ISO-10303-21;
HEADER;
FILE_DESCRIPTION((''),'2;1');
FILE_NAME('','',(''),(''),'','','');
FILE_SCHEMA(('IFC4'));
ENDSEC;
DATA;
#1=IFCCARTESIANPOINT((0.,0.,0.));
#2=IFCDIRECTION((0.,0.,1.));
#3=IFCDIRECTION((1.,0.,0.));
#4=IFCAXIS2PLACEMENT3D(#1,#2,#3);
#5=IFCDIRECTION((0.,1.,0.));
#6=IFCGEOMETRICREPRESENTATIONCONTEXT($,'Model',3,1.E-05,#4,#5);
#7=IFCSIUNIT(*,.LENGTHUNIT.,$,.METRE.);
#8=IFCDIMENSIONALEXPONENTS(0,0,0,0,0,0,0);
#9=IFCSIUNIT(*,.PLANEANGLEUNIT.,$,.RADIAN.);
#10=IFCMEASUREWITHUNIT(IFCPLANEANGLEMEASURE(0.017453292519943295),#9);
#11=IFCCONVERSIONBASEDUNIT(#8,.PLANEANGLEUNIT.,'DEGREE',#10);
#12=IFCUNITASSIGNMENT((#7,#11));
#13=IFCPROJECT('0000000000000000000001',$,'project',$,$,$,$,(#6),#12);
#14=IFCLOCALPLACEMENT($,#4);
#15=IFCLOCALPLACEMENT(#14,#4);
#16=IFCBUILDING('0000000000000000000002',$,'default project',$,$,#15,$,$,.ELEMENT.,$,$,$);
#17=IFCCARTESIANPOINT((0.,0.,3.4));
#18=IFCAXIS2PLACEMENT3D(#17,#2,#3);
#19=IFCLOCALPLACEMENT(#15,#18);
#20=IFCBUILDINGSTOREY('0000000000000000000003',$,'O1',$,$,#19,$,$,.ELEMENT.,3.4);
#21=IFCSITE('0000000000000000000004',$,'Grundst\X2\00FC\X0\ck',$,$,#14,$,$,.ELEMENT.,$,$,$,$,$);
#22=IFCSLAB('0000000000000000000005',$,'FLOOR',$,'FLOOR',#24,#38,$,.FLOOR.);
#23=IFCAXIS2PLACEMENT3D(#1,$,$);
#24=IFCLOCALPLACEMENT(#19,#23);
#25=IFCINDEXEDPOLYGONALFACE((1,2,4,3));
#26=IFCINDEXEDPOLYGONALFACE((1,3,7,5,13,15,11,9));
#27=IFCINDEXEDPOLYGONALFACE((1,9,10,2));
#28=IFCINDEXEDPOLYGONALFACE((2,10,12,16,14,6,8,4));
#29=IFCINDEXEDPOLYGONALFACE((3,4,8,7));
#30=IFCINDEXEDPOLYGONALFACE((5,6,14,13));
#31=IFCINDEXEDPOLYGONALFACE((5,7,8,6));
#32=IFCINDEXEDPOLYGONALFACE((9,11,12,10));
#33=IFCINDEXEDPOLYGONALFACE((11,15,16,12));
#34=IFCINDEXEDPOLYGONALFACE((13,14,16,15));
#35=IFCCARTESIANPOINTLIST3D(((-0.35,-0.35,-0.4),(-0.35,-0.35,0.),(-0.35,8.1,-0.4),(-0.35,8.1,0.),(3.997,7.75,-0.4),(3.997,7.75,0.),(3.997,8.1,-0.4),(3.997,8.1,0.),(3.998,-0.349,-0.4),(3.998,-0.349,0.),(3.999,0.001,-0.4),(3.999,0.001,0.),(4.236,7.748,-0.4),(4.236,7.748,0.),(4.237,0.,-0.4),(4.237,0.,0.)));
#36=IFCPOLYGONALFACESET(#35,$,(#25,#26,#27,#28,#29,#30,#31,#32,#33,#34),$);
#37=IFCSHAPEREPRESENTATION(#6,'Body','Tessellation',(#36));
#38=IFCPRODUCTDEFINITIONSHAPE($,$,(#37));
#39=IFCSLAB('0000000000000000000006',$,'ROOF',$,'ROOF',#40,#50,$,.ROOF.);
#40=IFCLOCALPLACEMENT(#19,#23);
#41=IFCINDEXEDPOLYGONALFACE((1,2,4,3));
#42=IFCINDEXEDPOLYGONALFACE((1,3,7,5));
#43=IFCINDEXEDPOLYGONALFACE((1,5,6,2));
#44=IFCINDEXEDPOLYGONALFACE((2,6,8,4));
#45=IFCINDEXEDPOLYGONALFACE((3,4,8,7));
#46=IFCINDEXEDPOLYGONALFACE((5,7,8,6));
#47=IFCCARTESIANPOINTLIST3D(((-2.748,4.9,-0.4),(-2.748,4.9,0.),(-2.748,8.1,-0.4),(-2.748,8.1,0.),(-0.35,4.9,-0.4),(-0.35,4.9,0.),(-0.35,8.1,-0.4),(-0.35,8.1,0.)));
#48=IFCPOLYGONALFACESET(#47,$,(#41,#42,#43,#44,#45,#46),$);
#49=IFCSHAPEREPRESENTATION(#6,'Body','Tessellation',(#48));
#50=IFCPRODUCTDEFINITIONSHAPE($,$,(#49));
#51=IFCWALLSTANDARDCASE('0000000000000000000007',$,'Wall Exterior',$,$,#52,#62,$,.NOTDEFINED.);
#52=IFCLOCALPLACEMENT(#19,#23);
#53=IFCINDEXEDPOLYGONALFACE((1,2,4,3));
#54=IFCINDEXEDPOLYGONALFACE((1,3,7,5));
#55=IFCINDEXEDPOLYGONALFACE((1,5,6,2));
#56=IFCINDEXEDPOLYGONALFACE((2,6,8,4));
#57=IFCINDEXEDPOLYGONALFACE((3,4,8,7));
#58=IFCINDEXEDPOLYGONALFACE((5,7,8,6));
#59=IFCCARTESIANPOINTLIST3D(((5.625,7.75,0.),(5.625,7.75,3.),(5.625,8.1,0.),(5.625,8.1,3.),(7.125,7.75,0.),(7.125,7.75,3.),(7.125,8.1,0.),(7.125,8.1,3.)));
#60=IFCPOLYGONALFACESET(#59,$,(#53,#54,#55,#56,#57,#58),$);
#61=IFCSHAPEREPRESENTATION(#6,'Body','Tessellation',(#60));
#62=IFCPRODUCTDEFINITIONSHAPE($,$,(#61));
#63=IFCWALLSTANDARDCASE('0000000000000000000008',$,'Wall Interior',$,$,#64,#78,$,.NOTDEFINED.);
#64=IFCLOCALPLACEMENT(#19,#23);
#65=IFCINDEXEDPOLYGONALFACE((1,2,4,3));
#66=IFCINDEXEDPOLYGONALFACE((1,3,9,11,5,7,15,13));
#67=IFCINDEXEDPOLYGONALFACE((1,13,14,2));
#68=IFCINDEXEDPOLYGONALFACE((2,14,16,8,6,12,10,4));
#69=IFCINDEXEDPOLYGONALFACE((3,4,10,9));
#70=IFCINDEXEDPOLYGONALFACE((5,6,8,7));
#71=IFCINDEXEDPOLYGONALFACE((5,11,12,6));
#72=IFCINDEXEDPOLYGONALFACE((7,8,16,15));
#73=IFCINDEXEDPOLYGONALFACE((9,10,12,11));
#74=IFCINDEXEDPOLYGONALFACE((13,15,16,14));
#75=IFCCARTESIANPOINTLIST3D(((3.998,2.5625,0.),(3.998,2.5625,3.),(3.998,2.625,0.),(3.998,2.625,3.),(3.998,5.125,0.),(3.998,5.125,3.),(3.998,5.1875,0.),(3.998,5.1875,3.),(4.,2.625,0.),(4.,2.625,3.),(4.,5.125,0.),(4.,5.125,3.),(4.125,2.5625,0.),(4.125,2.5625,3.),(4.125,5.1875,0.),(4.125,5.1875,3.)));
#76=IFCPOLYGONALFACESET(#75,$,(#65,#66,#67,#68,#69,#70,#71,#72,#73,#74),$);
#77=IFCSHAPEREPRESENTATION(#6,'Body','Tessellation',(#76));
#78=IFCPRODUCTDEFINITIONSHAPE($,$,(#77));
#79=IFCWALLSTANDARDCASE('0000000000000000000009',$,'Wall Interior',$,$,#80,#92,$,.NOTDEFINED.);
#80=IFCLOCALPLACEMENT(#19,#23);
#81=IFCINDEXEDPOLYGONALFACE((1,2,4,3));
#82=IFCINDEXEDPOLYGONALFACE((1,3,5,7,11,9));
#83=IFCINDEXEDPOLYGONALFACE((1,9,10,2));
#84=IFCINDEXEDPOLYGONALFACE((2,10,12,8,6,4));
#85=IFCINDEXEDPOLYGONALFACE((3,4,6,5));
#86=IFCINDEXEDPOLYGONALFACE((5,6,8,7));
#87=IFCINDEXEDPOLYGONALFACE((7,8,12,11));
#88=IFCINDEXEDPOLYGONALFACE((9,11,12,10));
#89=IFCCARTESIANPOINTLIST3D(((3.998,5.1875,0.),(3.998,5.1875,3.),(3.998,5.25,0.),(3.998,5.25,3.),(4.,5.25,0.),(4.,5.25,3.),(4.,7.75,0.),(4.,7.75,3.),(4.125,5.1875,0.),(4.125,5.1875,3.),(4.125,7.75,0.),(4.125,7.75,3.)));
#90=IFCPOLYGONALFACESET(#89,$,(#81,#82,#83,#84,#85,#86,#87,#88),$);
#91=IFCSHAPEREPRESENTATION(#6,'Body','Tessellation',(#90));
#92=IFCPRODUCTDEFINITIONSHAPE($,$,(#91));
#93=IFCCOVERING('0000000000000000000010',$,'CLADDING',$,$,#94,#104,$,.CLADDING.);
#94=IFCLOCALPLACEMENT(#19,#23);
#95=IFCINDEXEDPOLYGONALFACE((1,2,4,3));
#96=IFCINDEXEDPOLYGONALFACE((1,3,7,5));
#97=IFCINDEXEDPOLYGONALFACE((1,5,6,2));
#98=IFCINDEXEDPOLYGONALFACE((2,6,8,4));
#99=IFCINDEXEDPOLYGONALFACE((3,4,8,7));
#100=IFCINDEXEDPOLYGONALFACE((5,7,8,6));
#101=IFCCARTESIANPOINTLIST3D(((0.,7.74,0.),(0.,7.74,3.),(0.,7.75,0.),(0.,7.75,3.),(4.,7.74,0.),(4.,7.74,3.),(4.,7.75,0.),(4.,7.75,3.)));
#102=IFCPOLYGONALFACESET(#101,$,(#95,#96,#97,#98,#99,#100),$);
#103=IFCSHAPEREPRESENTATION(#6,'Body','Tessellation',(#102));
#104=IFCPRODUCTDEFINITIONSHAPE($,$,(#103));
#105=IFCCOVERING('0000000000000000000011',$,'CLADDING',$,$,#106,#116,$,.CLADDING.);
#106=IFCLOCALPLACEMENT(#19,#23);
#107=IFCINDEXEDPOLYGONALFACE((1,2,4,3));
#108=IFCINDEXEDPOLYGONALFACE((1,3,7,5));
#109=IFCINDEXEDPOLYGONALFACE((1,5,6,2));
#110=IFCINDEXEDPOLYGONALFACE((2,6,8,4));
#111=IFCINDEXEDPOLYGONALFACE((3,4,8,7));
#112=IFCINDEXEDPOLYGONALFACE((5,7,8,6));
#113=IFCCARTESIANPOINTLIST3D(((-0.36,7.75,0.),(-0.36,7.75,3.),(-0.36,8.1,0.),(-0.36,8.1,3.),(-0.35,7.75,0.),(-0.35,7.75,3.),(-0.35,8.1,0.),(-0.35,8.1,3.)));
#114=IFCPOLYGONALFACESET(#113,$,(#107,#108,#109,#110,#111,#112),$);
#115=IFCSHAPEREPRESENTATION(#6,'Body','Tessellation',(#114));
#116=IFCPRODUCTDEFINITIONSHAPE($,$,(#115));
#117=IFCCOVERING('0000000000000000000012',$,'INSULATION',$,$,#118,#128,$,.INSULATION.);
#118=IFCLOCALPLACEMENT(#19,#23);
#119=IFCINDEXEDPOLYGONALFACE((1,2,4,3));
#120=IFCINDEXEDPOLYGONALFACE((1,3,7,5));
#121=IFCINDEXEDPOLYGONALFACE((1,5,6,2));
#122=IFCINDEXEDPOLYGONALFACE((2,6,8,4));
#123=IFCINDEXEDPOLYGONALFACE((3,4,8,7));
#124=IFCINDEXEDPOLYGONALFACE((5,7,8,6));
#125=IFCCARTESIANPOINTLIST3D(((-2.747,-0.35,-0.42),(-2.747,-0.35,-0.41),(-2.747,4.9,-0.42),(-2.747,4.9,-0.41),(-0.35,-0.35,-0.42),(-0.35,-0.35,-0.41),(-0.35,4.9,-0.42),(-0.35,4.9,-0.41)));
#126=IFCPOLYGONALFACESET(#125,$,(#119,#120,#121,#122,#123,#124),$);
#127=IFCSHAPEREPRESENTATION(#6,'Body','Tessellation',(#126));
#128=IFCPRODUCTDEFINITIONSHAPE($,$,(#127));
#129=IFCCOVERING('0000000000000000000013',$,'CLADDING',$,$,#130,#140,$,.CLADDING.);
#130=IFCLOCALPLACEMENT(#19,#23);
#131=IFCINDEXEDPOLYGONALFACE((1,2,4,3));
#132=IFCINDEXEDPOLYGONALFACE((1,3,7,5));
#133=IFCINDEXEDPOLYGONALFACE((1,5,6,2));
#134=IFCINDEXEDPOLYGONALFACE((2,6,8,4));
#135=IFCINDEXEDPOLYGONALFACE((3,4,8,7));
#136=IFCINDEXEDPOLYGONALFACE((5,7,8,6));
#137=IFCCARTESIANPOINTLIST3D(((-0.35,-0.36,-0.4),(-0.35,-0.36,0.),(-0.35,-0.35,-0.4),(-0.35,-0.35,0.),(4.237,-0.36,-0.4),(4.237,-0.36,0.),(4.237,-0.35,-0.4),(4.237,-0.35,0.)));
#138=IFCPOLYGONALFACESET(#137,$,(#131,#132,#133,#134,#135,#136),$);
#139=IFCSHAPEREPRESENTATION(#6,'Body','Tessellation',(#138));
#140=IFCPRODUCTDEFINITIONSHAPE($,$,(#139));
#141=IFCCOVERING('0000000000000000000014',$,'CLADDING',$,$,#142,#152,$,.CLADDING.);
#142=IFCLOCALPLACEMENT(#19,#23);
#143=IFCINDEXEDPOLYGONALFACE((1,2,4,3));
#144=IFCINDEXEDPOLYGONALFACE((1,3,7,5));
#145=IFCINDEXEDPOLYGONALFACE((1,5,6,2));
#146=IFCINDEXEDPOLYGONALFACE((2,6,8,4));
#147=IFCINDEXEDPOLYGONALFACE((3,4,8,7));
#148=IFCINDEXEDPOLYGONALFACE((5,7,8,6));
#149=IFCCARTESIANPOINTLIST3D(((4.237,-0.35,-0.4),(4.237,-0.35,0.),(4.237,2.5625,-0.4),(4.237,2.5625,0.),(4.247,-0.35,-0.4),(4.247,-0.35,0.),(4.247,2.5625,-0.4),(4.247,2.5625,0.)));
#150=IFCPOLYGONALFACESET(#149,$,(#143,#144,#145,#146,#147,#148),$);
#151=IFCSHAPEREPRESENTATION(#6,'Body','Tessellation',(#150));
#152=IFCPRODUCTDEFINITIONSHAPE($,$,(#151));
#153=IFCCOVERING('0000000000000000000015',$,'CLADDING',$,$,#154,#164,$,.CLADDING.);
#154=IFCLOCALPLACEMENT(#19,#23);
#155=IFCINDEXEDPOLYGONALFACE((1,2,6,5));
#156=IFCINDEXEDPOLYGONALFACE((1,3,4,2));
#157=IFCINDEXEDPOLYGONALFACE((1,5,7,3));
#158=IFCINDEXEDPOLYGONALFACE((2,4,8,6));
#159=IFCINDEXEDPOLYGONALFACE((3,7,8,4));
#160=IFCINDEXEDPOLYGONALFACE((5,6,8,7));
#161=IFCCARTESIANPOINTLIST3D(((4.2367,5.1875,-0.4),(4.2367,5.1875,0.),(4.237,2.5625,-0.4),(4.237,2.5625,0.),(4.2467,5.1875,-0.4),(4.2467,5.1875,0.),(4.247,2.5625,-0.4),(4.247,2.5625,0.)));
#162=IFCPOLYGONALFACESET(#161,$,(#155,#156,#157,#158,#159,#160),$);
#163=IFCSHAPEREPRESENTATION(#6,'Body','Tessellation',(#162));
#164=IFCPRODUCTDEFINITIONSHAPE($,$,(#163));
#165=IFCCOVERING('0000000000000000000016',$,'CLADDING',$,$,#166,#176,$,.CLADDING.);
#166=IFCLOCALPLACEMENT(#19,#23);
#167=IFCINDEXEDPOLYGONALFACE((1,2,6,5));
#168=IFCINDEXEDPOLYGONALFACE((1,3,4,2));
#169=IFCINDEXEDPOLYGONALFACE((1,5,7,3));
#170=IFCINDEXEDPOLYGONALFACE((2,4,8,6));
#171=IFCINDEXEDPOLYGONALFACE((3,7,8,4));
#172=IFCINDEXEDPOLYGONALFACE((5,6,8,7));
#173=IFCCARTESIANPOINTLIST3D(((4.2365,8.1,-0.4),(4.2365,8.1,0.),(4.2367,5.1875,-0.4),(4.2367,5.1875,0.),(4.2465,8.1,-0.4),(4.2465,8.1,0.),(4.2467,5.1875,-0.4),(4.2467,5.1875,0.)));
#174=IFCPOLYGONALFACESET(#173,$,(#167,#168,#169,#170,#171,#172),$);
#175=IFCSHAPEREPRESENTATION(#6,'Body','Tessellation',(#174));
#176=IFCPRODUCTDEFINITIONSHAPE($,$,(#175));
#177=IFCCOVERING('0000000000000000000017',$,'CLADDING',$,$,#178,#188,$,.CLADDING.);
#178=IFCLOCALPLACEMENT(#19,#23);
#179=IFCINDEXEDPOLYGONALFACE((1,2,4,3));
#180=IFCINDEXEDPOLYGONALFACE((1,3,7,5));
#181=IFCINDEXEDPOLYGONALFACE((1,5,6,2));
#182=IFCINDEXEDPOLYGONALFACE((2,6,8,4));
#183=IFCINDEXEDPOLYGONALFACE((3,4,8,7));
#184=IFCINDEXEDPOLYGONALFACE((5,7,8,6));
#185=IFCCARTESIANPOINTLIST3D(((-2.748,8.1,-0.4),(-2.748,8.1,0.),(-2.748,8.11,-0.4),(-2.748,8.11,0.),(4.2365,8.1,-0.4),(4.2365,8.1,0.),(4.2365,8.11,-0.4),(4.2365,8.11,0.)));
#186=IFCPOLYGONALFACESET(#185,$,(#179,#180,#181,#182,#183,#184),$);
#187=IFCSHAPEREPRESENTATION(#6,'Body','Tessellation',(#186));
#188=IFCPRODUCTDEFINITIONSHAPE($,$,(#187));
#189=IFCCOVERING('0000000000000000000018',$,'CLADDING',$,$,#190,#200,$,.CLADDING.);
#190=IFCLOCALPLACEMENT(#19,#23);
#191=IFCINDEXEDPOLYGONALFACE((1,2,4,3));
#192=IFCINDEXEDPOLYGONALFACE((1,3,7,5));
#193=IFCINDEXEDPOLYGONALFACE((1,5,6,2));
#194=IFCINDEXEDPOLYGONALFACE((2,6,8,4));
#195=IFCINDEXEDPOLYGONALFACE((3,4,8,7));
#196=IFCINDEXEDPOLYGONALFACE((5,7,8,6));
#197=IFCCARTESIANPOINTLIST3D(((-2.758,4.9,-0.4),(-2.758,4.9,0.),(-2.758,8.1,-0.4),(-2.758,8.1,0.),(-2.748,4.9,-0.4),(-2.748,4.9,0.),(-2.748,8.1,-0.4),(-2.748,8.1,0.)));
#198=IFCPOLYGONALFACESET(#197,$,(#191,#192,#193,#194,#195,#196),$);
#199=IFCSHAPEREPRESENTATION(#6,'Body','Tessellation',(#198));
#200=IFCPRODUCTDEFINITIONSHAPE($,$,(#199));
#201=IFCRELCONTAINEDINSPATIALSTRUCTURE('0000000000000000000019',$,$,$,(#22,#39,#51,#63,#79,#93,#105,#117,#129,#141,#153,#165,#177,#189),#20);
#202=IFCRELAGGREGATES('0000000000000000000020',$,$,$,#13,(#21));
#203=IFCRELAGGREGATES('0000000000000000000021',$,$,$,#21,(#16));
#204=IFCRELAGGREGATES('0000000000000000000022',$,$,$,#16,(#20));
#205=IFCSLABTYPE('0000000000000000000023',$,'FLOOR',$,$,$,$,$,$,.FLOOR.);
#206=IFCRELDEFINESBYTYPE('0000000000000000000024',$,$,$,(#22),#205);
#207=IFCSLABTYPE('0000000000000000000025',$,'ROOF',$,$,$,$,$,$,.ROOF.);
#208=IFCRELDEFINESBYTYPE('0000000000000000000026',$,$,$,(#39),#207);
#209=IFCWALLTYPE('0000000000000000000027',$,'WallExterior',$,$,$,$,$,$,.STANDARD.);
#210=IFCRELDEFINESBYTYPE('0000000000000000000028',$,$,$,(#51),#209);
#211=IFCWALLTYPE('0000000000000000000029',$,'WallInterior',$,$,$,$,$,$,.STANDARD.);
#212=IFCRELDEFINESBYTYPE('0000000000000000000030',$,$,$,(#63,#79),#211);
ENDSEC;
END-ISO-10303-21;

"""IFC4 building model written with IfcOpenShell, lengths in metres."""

from ifc_helpers import new_model, entity, si_unit, converted_unit, direction, frame, origin_with_axes, place, context, project, spatial, polyline, outline, extrude, type_object, element, save


model = new_model("IFC4")

# Units and contexts
model_context = context("Model", 3, precision=1e-05, world=origin_with_axes(), true_north=direction((0.0, 1.0, 0.0)))
ifc_project = project(units=[si_unit("LENGTHUNIT", "METRE"), converted_unit("PLANEANGLEUNIT", "DEGREE", entity("IfcPlaneAngleMeasure", 0.017453292519943295), si_unit("PLANEANGLEUNIT", "RADIAN"), dimensions=[0, 0, 0, 0, 0, 0, 0])], contexts=[model_context])

# Site, building, storey
site_placement = place(None, origin_with_axes())
site = spatial("IfcSite", under=ifc_project, at=site_placement, Name="Grundstück", CompositionType="ELEMENT")
building_placement = place(site_placement, origin_with_axes())
building = spatial("IfcBuilding", under=site, at=building_placement, Name="default project", CompositionType="ELEMENT")
placement_1 = place(building_placement, frame((0.0, 0.0, 3.4), z_axis=(0.0, 0.0, 1.0), x_axis=(1.0, 0.0, 0.0)))
storey = spatial("IfcBuildingStorey", under=building, at=placement_1, Name="O1", CompositionType="ELEMENT", Elevation=3.4)

# Slabs
slab_type_1 = type_object("IfcSlabType", Name="FLOOR", PredefinedType="FLOOR")
slab_1_placement = place(placement_1, frame((0.0, 0.0, -0.4), z_axis=(0.0, 0.0, 1.0), x_axis=(1.0, 0.0, 0.0)))
element("IfcSlab", 1, at=slab_1_placement, inside=storey, type_object=slab_type_1, Name="FLOOR", ObjectType="FLOOR", PredefinedType="FLOOR", context=model_context, shape_type="SweptSolid", body=[
    extrude(outline(polyline([(4.237, 0.0), (4.236, 7.748), (3.997, 7.75), (3.997, 8.1), (-0.35, 8.1), (-0.35, -0.35), (3.998, -0.349), (3.999, 0.001), (4.237, 0.0)])), origin_with_axes(), (0.0, 0.0, 1.0), 0.4),
])
slab_type_2 = type_object("IfcSlabType", Name="ROOF", PredefinedType="ROOF")
slab_2_placement = place(placement_1, frame((0.0, 0.0, -0.4), z_axis=(0.0, 0.0, 1.0), x_axis=(1.0, 0.0, 0.0)))
element("IfcSlab", 2, at=slab_2_placement, inside=storey, type_object=slab_type_2, Name="ROOF", ObjectType="ROOF", PredefinedType="ROOF", context=model_context, shape_type="SweptSolid", body=[
    extrude(outline(polyline([(-0.35, 8.1), (-2.748, 8.1), (-2.748, 4.9), (-0.35, 4.9), (-0.35, 8.1)])), origin_with_axes(), (0.0, 0.0, 1.0), 0.4),
])

# Walls
wall_type_1 = type_object("IfcWallType", Name="WallExterior", PredefinedType="STANDARD")
placement_2 = place(placement_1, frame((5.625, 7.925, 0.0), z_axis=(0.0, 0.0, 1.0), x_axis=(1.0, 0.0, 0.0)))
element("IfcWallStandardCase", 3, at=placement_2, inside=storey, type_object=wall_type_1, Name="Wall Exterior", PredefinedType="NOTDEFINED", context=model_context, shape_type="SweptSolid", body=[
    extrude(outline(polyline([(1.5, 0.175), (0.0, 0.175), (0.0, -0.175), (1.5, -0.175), (1.5, 0.175)])), origin_with_axes(), (0.0, 0.0, 1.0), 3.0),
])
placement_3 = place(placement_1, frame((-0.175, 7.925, 0.0), z_axis=(0.0, 0.0, 1.0), x_axis=(1.0, 0.0, 0.0)))
wall_type_2 = type_object("IfcWallType", Name="WallInterior", PredefinedType="STANDARD")
wall_1_placement = place(placement_1, frame((4.0625, 2.5625, 0.0), z_axis=(0.0, 0.0, 1.0), x_axis=(0.0, 1.0, 0.0)))
element("IfcWallStandardCase", 4, at=wall_1_placement, inside=storey, type_object=wall_type_2, Name="Wall Interior", PredefinedType="NOTDEFINED", context=model_context, shape_type="SweptSolid", body=[
    extrude(outline(polyline([(2.5625, 0.0625), (0.0625, 0.0625), (0.0625, 0.0645), (0.0, 0.0645), (0.0, -0.0625), (2.625, -0.0625), (2.625, 0.0645), (2.5625, 0.0645), (2.5625, 0.0625)])), origin_with_axes(), (0.0, 0.0, 1.0), 3.0),
])
wall_2_placement = place(placement_1, frame((4.0625, 5.1875, 0.0), z_axis=(0.0, 0.0, 1.0), x_axis=(0.0, 1.0, 0.0)))
element("IfcWallStandardCase", 5, at=wall_2_placement, inside=storey, type_object=wall_type_2, Name="Wall Interior", PredefinedType="NOTDEFINED", context=model_context, shape_type="SweptSolid", body=[
    extrude(outline(polyline([(0.0625, 0.0645), (0.0, 0.0645), (0.0, -0.0625), (2.5625, -0.0625), (2.5625, 0.0625), (0.0625, 0.0625), (0.0625, 0.0645)])), origin_with_axes(), (0.0, 0.0, 1.0), 3.0),
])

# Coverings
element("IfcCovering", 6, at=placement_1, inside=storey, Name="CLADDING", PredefinedType="CLADDING", context=model_context, shape_type="SweptSolid", body=[
    extrude(outline(polyline([(0.0, 7.74), (4.0, 7.74), (4.0, 7.75), (0.0, 7.75), (0.0, 7.74)])), origin_with_axes(), (0.0, 0.0, 1.0), 3.0),
])
element("IfcCovering", 7, at=placement_3, inside=storey, Name="CLADDING", PredefinedType="CLADDING", context=model_context, shape_type="SweptSolid", body=[
    extrude(outline(polyline([(-0.185, 0.175), (-0.185, -0.175), (-0.175, -0.175), (-0.175, 0.175), (-0.185, 0.175)])), origin_with_axes(), (0.0, 0.0, 1.0), 3.0),
])
placement_4 = place(placement_1, frame((0.0, 0.0, -0.4), z_axis=(0.0, 0.0, 1.0), x_axis=(1.0, 0.0, 0.0)))
covering_1_placement = place(placement_4, frame((0.0, 0.0, -0.01), z_axis=(0.0, 0.0, 1.0), x_axis=(1.0, 0.0, 0.0)))
element("IfcCovering", 8, at=covering_1_placement, inside=storey, Name="INSULATION", PredefinedType="INSULATION", context=model_context, shape_type="SweptSolid", body=[
    extrude(outline(polyline([(-0.35, 4.9), (-2.747, 4.9), (-2.747, -0.35), (-0.35, -0.35), (-0.35, 4.9)])), frame((0.0, 0.0, -0.01), z_axis=(0.0, 0.0, 1.0), x_axis=(1.0, 0.0, 0.0)), (0.0, 0.0, 1.0), 0.01),
])
covering_2_placement = place(slab_1_placement, origin_with_axes())
element("IfcCovering", 9, at=covering_2_placement, inside=storey, Name="CLADDING", PredefinedType="CLADDING", context=model_context, shape_type="SweptSolid", body=[
    extrude(outline(polyline([(-0.35, -0.36), (4.237, -0.36), (4.237, -0.35), (-0.35, -0.35), (-0.35, -0.36)])), origin_with_axes(), (0.0, 0.0, 1.0), 0.4),
])
covering_3_placement = place(slab_1_placement, origin_with_axes())
element("IfcCovering", 10, at=covering_3_placement, inside=storey, Name="CLADDING", PredefinedType="CLADDING", context=model_context, shape_type="SweptSolid", body=[
    extrude(outline(polyline([(4.247, -0.35), (4.247, 2.5625), (4.237, 2.5625), (4.237, -0.35), (4.247, -0.35)])), origin_with_axes(), (0.0, 0.0, 1.0), 0.4),
])
covering_4_placement = place(slab_1_placement, origin_with_axes())
element("IfcCovering", 11, at=covering_4_placement, inside=storey, Name="CLADDING", PredefinedType="CLADDING", context=model_context, shape_type="SweptSolid", body=[
    extrude(outline(polyline([(4.247, 2.5625), (4.2467, 5.1875), (4.2367, 5.1875), (4.237, 2.5625), (4.247, 2.5625)])), origin_with_axes(), (0.0, 0.0, 1.0), 0.4),
])
covering_5_placement = place(slab_1_placement, origin_with_axes())
element("IfcCovering", 12, at=covering_5_placement, inside=storey, Name="CLADDING", PredefinedType="CLADDING", context=model_context, shape_type="SweptSolid", body=[
    extrude(outline(polyline([(4.2467, 5.1875), (4.2465, 8.1), (4.2365, 8.1), (4.2367, 5.1875), (4.2467, 5.1875)])), origin_with_axes(), (0.0, 0.0, 1.0), 0.4),
])
covering_6_placement = place(slab_1_placement, origin_with_axes())
element("IfcCovering", 13, at=covering_6_placement, inside=storey, Name="CLADDING", PredefinedType="CLADDING", context=model_context, shape_type="SweptSolid", body=[
    extrude(outline(polyline([(4.2365, 8.11), (-2.748, 8.11), (-2.748, 8.1), (4.2365, 8.1), (4.2365, 8.11)])), origin_with_axes(), (0.0, 0.0, 1.0), 0.4),
])
covering_7_placement = place(slab_1_placement, origin_with_axes())
element("IfcCovering", 14, at=covering_7_placement, inside=storey, Name="CLADDING", PredefinedType="CLADDING", context=model_context, shape_type="SweptSolid", body=[
    extrude(outline(polyline([(-2.758, 8.1), (-2.758, 4.9), (-2.748, 4.9), (-2.748, 8.1), (-2.758, 8.1)])), origin_with_axes(), (0.0, 0.0, 1.0), 0.4),
])

save(model, "model.ifc")
